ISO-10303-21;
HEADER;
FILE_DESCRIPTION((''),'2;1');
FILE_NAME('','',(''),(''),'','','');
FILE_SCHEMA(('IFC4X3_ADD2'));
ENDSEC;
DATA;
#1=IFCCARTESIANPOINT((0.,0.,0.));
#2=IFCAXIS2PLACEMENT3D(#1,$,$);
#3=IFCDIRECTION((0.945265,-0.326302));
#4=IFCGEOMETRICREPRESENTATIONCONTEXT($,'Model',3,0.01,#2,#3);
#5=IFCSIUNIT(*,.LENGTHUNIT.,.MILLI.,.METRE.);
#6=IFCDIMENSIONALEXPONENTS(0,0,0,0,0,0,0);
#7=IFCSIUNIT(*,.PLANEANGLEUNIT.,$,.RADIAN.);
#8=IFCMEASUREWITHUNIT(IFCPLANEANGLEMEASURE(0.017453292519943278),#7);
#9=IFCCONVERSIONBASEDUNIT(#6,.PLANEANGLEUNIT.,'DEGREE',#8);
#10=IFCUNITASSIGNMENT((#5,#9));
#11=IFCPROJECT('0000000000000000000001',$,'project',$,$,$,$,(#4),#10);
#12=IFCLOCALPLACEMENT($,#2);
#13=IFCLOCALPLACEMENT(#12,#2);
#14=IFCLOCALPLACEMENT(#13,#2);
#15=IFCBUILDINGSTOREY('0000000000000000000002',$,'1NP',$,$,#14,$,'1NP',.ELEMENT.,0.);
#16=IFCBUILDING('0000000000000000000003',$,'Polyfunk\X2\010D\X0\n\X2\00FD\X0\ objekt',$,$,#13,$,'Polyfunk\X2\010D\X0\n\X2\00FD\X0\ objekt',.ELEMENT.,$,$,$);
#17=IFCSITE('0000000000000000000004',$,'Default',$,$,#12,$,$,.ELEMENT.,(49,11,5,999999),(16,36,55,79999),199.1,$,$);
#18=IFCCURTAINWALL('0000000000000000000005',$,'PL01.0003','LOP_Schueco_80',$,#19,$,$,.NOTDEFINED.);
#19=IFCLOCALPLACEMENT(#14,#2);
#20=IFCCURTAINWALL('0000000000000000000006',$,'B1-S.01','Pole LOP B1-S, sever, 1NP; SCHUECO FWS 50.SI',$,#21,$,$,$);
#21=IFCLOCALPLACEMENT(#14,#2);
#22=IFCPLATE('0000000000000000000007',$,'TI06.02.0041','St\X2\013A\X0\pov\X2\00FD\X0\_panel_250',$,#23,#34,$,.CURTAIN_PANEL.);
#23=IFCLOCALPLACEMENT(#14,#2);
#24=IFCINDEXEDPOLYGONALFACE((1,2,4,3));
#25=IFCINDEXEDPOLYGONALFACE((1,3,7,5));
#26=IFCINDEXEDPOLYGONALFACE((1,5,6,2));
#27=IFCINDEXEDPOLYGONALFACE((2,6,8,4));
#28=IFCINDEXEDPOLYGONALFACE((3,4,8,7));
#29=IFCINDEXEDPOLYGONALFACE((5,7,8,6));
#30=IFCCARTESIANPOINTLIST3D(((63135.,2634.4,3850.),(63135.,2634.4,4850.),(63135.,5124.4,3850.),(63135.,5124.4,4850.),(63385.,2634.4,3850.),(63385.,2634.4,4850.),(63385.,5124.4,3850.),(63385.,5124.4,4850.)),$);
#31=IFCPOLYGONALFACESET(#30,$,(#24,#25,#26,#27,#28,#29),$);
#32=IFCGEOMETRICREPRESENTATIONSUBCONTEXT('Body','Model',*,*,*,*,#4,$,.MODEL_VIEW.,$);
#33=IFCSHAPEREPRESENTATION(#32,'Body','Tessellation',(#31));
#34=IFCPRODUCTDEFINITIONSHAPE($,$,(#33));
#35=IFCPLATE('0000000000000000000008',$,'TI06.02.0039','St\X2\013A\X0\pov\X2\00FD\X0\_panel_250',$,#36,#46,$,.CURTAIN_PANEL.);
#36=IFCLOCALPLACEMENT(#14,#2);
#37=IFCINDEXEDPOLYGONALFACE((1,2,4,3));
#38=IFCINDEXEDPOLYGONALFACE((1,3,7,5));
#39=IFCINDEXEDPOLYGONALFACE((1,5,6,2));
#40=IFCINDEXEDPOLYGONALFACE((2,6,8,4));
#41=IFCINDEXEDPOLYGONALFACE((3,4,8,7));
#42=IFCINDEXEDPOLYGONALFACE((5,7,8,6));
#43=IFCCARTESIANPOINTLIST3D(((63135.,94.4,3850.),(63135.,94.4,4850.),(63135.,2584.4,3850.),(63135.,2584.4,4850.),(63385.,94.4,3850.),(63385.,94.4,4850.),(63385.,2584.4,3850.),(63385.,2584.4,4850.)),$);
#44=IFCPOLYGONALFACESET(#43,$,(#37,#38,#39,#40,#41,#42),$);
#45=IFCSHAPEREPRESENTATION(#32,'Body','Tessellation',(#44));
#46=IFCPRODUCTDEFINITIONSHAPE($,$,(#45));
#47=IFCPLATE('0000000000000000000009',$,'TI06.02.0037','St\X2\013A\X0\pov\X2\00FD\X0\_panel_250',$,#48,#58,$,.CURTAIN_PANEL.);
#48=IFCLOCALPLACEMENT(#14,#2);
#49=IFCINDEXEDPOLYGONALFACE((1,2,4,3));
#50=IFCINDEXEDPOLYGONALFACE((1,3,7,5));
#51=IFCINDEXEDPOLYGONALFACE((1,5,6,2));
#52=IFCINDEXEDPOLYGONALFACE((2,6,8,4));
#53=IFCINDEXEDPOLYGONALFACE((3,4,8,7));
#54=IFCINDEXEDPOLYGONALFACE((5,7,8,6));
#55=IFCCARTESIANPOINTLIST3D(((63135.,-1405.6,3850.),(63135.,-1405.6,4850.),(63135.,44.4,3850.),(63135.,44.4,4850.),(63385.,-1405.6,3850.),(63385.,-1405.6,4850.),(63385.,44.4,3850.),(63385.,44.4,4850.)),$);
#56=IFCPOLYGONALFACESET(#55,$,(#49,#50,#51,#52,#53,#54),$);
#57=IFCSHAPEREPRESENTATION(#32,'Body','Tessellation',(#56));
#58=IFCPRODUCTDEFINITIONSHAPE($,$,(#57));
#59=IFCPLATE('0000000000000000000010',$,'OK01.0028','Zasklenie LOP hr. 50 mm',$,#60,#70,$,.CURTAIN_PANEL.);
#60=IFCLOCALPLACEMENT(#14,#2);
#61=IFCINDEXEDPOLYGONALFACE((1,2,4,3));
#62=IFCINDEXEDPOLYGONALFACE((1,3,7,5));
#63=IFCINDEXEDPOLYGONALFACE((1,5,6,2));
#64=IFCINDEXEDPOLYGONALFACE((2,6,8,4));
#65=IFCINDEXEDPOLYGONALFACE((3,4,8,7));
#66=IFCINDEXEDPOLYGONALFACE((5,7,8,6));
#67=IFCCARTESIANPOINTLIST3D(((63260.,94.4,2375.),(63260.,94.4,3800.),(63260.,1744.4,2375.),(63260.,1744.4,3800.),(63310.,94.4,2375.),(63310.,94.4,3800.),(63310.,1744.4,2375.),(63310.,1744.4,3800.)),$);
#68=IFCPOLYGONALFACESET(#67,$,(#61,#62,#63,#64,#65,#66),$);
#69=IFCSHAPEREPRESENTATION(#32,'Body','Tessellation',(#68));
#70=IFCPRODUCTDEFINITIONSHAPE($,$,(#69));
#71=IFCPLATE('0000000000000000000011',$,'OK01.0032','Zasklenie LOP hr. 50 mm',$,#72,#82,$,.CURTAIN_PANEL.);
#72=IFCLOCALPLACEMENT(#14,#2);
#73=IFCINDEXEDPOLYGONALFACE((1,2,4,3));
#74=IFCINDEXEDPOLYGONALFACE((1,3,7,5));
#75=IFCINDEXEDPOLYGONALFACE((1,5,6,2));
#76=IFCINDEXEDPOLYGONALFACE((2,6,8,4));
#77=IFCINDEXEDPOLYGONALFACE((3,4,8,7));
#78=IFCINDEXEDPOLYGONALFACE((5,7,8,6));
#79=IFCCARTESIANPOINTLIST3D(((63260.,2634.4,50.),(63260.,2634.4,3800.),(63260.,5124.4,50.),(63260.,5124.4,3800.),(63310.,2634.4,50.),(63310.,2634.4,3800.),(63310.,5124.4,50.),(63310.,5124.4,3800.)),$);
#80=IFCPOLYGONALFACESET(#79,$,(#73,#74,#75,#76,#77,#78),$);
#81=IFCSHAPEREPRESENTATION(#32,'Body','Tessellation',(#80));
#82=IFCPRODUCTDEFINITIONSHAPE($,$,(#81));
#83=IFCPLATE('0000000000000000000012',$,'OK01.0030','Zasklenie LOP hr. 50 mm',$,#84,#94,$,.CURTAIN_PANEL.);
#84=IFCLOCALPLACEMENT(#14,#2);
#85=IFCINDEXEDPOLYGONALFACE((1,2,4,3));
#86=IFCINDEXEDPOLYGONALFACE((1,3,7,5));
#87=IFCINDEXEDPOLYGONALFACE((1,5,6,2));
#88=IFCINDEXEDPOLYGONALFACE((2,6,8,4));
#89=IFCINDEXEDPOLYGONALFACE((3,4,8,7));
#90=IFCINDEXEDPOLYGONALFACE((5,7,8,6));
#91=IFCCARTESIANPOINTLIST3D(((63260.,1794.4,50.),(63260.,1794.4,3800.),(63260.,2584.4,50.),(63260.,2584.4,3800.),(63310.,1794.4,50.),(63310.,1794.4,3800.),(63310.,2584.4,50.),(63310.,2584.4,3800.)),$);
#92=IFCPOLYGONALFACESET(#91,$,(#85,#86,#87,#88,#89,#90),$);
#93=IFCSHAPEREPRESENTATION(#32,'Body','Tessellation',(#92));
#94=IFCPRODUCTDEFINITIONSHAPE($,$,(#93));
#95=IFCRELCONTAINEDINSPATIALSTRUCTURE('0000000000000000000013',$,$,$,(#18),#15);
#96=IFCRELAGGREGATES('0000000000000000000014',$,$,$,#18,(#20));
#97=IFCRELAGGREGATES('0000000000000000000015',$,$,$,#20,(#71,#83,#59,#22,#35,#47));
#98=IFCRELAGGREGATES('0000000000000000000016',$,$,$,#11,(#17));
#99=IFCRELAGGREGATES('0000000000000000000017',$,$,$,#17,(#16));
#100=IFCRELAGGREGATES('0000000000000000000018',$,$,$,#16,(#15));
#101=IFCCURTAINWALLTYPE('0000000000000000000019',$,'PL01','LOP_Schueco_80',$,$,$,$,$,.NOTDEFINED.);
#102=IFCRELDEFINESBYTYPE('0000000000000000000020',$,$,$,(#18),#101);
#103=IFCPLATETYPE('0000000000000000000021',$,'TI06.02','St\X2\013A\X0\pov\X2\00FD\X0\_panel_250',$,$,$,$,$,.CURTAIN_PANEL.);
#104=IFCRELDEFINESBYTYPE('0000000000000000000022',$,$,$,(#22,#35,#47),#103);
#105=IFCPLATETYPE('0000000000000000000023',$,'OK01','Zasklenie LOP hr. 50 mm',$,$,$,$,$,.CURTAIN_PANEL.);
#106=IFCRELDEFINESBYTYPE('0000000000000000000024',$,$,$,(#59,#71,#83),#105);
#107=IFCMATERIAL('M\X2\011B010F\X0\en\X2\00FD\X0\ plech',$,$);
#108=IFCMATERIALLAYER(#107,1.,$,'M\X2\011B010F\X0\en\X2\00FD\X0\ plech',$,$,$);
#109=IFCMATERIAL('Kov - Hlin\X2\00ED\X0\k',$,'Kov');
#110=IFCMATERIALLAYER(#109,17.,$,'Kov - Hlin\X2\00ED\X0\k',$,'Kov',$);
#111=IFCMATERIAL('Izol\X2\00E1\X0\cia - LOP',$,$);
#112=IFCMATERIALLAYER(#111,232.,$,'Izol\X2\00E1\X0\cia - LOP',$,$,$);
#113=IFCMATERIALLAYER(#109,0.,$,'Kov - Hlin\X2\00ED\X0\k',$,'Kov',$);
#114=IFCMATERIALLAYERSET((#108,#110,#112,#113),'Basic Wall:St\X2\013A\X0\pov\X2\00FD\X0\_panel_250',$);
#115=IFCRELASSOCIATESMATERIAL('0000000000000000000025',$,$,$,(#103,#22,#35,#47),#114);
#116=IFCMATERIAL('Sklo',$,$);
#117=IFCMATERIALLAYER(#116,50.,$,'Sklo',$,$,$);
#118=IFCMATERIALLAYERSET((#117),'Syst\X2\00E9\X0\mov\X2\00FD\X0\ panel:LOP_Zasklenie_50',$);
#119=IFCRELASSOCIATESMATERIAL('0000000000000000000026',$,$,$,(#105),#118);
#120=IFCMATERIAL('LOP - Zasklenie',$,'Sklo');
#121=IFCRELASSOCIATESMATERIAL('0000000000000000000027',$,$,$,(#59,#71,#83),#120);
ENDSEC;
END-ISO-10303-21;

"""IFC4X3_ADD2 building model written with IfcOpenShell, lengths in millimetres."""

from ifc_helpers import new_model, entity, si_unit, converted_unit, direction, frame, frame_2d, origin, origin_2d_with_axis, place, context, subcontext, project, spatial, rectangle, extrude, source, transform, mapped, material, layer, layer_set, layer_usage, type_object, type_shapes, element, aggregate, save


model = new_model("IFC4X3_ADD2")

# Units and contexts
model_context = context("Model", 3, precision=0.01, world=origin(), true_north=direction((0.945265, -0.326302)))
body_context = subcontext(model_context, "Body", "Model", "MODEL_VIEW")
ifc_project = project(units=[si_unit("LENGTHUNIT", "METRE", prefix="MILLI"), converted_unit("PLANEANGLEUNIT", "DEGREE", entity("IfcPlaneAngleMeasure", 0.017453292519943278), si_unit("PLANEANGLEUNIT", "RADIAN"), dimensions=[0, 0, 0, 0, 0, 0, 0])], contexts=[model_context])

# Site, building, storey
site_placement = place(None, origin())
site = spatial("IfcSite", under=ifc_project, at=site_placement, Name="Default", CompositionType="ELEMENT", RefLatitude=(49, 11, 5, 999999), RefLongitude=(16, 36, 55, 79999), RefElevation=199.1)
building_placement = place(site_placement, origin())
building = spatial("IfcBuilding", under=site, at=building_placement, Name="Polyfunkčný objekt", LongName="Polyfunkčný objekt", CompositionType="ELEMENT")
storey_placement = place(building_placement, origin())
storey = spatial("IfcBuildingStorey", under=building, at=storey_placement, Name="1NP", LongName="1NP", CompositionType="ELEMENT", Elevation=0.0)

# Curtain walls, plates
curtain_wall_type = type_object("IfcCurtainWallType", Name="PL01", Description="LOP_Schueco_80", PredefinedType="NOTDEFINED")
curtain_wall_1_placement = place(storey_placement, origin())
curtain_wall_1 = element("IfcCurtainWall", 1, at=curtain_wall_1_placement, inside=storey, type_object=curtain_wall_type, Name="PL01.0003", Description="LOP_Schueco_80", PredefinedType="NOTDEFINED")
curtain_wall_2 = element("IfcCurtainWall", 2, Name="B1-S.01", Description="Pole LOP B1-S, sever, 1NP; SCHUECO FWS 50.SI")
aggregate(curtain_wall_1, [curtain_wall_2])
ifc_material_1 = material(Name="Měďený plech")
ifc_layer_1 = layer(ifc_material_1, 1.0, Name="Měďený plech")
ifc_material_2 = material(Name="Kov - Hliník", Category="Kov")
ifc_layer_2 = layer(ifc_material_2, 17.0, Name="Kov - Hliník", Category="Kov")
ifc_material_3 = material(Name="Izolácia - LOP")
ifc_layer_3 = layer(ifc_material_3, 232.0, Name="Izolácia - LOP")
ifc_layer_4 = layer(ifc_material_2, 0.0, Name="Kov - Hliník", Category="Kov")
ifc_layer_set_1 = layer_set([ifc_layer_1, ifc_layer_2, ifc_layer_3, ifc_layer_4], Name="Basic Wall:Stĺpový_panel_250")
ifc_layer_usage_1 = layer_usage(ifc_layer_set_1, "AXIS2", "NEGATIVE", 125.0)
plate_type_1 = type_object("IfcPlateType", Name="TI06.02", Description="Stĺpový_panel_250", PredefinedType="CURTAIN_PANEL", material=ifc_layer_set_1)
plate_1_placement = place(storey_placement, frame((63260.0, 5124.4, 3850.0), z_axis=(0.0, 0.0, 1.0), x_axis=(0.0, -1.0, 0.0)))
plate_1 = element("IfcPlate", 3, at=plate_1_placement, type_object=plate_type_1, material=ifc_layer_usage_1, Name="TI06.02.0041", Description="Stĺpový_panel_250", PredefinedType="CURTAIN_PANEL", context=body_context, shape_type="SweptSolid", body=[
    extrude(rectangle(XDim=250.0, YDim=2490.0, at=frame_2d((0.0, 0.0), x_axis=(1.0, 0.0))), frame((1245.0, 0.0, 0.0), z_axis=(0.0, 0.0, 1.0), x_axis=(0.0, 1.0, 0.0)), (0.0, 0.0, 1.0), 1000.0),
])
ifc_layer_usage_2 = layer_usage(ifc_layer_set_1, "AXIS2", "NEGATIVE", 125.0)
plate_2_placement = place(storey_placement, frame((63260.0, 2584.4, 3850.0), z_axis=(0.0, 0.0, 1.0), x_axis=(0.0, -1.0, 0.0)))
plate_2 = element("IfcPlate", 4, at=plate_2_placement, type_object=plate_type_1, material=ifc_layer_usage_2, Name="TI06.02.0039", Description="Stĺpový_panel_250", PredefinedType="CURTAIN_PANEL", context=body_context, shape_type="SweptSolid", body=[
    extrude(rectangle(XDim=250.0, YDim=2490.0, at=frame_2d((0.0, 0.0), x_axis=(1.0, 0.0))), frame((1245.0, 0.0, 0.0), z_axis=(0.0, 0.0, 1.0), x_axis=(0.0, 1.0, 0.0)), (0.0, 0.0, 1.0), 1000.0),
])
ifc_layer_usage_3 = layer_usage(ifc_layer_set_1, "AXIS2", "NEGATIVE", 125.0)
plate_3_placement = place(storey_placement, frame((63260.0, 44.4, 3850.0), z_axis=(0.0, 0.0, 1.0), x_axis=(0.0, -1.0, 0.0)))
plate_3 = element("IfcPlate", 5, at=plate_3_placement, type_object=plate_type_1, material=ifc_layer_usage_3, Name="TI06.02.0037", Description="Stĺpový_panel_250", PredefinedType="CURTAIN_PANEL", context=body_context, shape_type="SweptSolid", body=[
    extrude(rectangle(XDim=250.0, YDim=1450.0, at=frame_2d((0.0, 0.0), x_axis=(1.0, 0.0))), frame((725.0, 0.0, 0.0), z_axis=(0.0, 0.0, 1.0), x_axis=(0.0, 1.0, 0.0)), (0.0, 0.0, 1.0), 1000.0),
])
ifc_material_4 = material(Name="LOP - Zasklenie", Category="Sklo")
ifc_material_5 = material(Name="Sklo")
ifc_layer_5 = layer(ifc_material_5, 50.0, Name="Sklo")
ifc_layer_set_2 = layer_set([ifc_layer_5], Name="Systémový panel:LOP_Zasklenie_50")
plate_type_2 = type_object("IfcPlateType", Name="OK01", Description="Zasklenie LOP hr. 50 mm", PredefinedType="CURTAIN_PANEL", material=ifc_layer_set_2)
shared_shape_1 = source(origin(), body_context, "Body", "SweptSolid", [
    extrude(rectangle(XDim=50.0, YDim=1650.0, at=origin_2d_with_axis()), frame((0.0, 25.0, 0.0), z_axis=(0.0, 0.0, 1.0), x_axis=(0.0, 1.0, 0.0)), (0.0, 0.0, 1.0), 1425.0),
])
plate_4_placement = place(curtain_wall_1_placement, frame((63260.0, 919.4, 2375.0), z_axis=(0.0, 0.0, 1.0), x_axis=(0.0, -1.0, 0.0)))
plate_4 = element("IfcPlate", 6, at=plate_4_placement, type_object=plate_type_2, material=ifc_material_4, Name="OK01.0028", Description="Zasklenie LOP hr. 50 mm", PredefinedType="CURTAIN_PANEL", context=body_context, shape_type="MappedRepresentation", body=[
    mapped(shared_shape_1, transform((0.0, 0.0, 0.0), scale=1.0)),
])
shared_shape_2 = source(origin(), body_context, "Body", "SweptSolid", [
    extrude(rectangle(XDim=3750.0, YDim=2490.0, at=frame_2d((-141.7, 0.0), x_axis=(1.0, 0.0))), frame((0.0, 0.0, 2016.7), z_axis=(0.0, 1.0, 0.0), x_axis=(0.0, 0.0, 1.0)), (0.0, 0.0, 1.0), 50.0),
])
plate_5_placement = place(curtain_wall_1_placement, frame((63260.0, 3879.4, 50.0), z_axis=(0.0, 0.0, 1.0), x_axis=(0.0, -1.0, 0.0)))
plate_5 = element("IfcPlate", 7, at=plate_5_placement, type_object=plate_type_2, material=ifc_material_4, Name="OK01.0032", Description="Zasklenie LOP hr. 50 mm", PredefinedType="CURTAIN_PANEL", context=body_context, shape_type="MappedRepresentation", body=[
    mapped(shared_shape_2, transform((0.0, 0.0, 0.0), scale=1.0)),
])
shared_shape_3 = source(origin(), body_context, "Body", "SweptSolid", [
    extrude(rectangle(XDim=3750.0, YDim=790.0, at=frame_2d((-141.7, 0.0), x_axis=(1.0, 0.0))), frame((0.0, 0.0, 2016.7), z_axis=(0.0, 1.0, 0.0), x_axis=(0.0, 0.0, 1.0)), (0.0, 0.0, 1.0), 50.0),
])
type_shapes(plate_type_2, [shared_shape_1, shared_shape_2, shared_shape_3])
plate_6_placement = place(curtain_wall_1_placement, frame((63260.0, 2189.4, 50.0), z_axis=(0.0, 0.0, 1.0), x_axis=(0.0, -1.0, 0.0)))
plate_6 = element("IfcPlate", 8, at=plate_6_placement, type_object=plate_type_2, material=ifc_material_4, Name="OK01.0030", Description="Zasklenie LOP hr. 50 mm", PredefinedType="CURTAIN_PANEL", context=body_context, shape_type="MappedRepresentation", body=[
    mapped(shared_shape_3, transform((0.0, 0.0, 0.0), scale=1.0)),
])
aggregate(curtain_wall_2, [plate_5, plate_6, plate_4, plate_1, plate_2, plate_3])

save(model, "model.ifc")
